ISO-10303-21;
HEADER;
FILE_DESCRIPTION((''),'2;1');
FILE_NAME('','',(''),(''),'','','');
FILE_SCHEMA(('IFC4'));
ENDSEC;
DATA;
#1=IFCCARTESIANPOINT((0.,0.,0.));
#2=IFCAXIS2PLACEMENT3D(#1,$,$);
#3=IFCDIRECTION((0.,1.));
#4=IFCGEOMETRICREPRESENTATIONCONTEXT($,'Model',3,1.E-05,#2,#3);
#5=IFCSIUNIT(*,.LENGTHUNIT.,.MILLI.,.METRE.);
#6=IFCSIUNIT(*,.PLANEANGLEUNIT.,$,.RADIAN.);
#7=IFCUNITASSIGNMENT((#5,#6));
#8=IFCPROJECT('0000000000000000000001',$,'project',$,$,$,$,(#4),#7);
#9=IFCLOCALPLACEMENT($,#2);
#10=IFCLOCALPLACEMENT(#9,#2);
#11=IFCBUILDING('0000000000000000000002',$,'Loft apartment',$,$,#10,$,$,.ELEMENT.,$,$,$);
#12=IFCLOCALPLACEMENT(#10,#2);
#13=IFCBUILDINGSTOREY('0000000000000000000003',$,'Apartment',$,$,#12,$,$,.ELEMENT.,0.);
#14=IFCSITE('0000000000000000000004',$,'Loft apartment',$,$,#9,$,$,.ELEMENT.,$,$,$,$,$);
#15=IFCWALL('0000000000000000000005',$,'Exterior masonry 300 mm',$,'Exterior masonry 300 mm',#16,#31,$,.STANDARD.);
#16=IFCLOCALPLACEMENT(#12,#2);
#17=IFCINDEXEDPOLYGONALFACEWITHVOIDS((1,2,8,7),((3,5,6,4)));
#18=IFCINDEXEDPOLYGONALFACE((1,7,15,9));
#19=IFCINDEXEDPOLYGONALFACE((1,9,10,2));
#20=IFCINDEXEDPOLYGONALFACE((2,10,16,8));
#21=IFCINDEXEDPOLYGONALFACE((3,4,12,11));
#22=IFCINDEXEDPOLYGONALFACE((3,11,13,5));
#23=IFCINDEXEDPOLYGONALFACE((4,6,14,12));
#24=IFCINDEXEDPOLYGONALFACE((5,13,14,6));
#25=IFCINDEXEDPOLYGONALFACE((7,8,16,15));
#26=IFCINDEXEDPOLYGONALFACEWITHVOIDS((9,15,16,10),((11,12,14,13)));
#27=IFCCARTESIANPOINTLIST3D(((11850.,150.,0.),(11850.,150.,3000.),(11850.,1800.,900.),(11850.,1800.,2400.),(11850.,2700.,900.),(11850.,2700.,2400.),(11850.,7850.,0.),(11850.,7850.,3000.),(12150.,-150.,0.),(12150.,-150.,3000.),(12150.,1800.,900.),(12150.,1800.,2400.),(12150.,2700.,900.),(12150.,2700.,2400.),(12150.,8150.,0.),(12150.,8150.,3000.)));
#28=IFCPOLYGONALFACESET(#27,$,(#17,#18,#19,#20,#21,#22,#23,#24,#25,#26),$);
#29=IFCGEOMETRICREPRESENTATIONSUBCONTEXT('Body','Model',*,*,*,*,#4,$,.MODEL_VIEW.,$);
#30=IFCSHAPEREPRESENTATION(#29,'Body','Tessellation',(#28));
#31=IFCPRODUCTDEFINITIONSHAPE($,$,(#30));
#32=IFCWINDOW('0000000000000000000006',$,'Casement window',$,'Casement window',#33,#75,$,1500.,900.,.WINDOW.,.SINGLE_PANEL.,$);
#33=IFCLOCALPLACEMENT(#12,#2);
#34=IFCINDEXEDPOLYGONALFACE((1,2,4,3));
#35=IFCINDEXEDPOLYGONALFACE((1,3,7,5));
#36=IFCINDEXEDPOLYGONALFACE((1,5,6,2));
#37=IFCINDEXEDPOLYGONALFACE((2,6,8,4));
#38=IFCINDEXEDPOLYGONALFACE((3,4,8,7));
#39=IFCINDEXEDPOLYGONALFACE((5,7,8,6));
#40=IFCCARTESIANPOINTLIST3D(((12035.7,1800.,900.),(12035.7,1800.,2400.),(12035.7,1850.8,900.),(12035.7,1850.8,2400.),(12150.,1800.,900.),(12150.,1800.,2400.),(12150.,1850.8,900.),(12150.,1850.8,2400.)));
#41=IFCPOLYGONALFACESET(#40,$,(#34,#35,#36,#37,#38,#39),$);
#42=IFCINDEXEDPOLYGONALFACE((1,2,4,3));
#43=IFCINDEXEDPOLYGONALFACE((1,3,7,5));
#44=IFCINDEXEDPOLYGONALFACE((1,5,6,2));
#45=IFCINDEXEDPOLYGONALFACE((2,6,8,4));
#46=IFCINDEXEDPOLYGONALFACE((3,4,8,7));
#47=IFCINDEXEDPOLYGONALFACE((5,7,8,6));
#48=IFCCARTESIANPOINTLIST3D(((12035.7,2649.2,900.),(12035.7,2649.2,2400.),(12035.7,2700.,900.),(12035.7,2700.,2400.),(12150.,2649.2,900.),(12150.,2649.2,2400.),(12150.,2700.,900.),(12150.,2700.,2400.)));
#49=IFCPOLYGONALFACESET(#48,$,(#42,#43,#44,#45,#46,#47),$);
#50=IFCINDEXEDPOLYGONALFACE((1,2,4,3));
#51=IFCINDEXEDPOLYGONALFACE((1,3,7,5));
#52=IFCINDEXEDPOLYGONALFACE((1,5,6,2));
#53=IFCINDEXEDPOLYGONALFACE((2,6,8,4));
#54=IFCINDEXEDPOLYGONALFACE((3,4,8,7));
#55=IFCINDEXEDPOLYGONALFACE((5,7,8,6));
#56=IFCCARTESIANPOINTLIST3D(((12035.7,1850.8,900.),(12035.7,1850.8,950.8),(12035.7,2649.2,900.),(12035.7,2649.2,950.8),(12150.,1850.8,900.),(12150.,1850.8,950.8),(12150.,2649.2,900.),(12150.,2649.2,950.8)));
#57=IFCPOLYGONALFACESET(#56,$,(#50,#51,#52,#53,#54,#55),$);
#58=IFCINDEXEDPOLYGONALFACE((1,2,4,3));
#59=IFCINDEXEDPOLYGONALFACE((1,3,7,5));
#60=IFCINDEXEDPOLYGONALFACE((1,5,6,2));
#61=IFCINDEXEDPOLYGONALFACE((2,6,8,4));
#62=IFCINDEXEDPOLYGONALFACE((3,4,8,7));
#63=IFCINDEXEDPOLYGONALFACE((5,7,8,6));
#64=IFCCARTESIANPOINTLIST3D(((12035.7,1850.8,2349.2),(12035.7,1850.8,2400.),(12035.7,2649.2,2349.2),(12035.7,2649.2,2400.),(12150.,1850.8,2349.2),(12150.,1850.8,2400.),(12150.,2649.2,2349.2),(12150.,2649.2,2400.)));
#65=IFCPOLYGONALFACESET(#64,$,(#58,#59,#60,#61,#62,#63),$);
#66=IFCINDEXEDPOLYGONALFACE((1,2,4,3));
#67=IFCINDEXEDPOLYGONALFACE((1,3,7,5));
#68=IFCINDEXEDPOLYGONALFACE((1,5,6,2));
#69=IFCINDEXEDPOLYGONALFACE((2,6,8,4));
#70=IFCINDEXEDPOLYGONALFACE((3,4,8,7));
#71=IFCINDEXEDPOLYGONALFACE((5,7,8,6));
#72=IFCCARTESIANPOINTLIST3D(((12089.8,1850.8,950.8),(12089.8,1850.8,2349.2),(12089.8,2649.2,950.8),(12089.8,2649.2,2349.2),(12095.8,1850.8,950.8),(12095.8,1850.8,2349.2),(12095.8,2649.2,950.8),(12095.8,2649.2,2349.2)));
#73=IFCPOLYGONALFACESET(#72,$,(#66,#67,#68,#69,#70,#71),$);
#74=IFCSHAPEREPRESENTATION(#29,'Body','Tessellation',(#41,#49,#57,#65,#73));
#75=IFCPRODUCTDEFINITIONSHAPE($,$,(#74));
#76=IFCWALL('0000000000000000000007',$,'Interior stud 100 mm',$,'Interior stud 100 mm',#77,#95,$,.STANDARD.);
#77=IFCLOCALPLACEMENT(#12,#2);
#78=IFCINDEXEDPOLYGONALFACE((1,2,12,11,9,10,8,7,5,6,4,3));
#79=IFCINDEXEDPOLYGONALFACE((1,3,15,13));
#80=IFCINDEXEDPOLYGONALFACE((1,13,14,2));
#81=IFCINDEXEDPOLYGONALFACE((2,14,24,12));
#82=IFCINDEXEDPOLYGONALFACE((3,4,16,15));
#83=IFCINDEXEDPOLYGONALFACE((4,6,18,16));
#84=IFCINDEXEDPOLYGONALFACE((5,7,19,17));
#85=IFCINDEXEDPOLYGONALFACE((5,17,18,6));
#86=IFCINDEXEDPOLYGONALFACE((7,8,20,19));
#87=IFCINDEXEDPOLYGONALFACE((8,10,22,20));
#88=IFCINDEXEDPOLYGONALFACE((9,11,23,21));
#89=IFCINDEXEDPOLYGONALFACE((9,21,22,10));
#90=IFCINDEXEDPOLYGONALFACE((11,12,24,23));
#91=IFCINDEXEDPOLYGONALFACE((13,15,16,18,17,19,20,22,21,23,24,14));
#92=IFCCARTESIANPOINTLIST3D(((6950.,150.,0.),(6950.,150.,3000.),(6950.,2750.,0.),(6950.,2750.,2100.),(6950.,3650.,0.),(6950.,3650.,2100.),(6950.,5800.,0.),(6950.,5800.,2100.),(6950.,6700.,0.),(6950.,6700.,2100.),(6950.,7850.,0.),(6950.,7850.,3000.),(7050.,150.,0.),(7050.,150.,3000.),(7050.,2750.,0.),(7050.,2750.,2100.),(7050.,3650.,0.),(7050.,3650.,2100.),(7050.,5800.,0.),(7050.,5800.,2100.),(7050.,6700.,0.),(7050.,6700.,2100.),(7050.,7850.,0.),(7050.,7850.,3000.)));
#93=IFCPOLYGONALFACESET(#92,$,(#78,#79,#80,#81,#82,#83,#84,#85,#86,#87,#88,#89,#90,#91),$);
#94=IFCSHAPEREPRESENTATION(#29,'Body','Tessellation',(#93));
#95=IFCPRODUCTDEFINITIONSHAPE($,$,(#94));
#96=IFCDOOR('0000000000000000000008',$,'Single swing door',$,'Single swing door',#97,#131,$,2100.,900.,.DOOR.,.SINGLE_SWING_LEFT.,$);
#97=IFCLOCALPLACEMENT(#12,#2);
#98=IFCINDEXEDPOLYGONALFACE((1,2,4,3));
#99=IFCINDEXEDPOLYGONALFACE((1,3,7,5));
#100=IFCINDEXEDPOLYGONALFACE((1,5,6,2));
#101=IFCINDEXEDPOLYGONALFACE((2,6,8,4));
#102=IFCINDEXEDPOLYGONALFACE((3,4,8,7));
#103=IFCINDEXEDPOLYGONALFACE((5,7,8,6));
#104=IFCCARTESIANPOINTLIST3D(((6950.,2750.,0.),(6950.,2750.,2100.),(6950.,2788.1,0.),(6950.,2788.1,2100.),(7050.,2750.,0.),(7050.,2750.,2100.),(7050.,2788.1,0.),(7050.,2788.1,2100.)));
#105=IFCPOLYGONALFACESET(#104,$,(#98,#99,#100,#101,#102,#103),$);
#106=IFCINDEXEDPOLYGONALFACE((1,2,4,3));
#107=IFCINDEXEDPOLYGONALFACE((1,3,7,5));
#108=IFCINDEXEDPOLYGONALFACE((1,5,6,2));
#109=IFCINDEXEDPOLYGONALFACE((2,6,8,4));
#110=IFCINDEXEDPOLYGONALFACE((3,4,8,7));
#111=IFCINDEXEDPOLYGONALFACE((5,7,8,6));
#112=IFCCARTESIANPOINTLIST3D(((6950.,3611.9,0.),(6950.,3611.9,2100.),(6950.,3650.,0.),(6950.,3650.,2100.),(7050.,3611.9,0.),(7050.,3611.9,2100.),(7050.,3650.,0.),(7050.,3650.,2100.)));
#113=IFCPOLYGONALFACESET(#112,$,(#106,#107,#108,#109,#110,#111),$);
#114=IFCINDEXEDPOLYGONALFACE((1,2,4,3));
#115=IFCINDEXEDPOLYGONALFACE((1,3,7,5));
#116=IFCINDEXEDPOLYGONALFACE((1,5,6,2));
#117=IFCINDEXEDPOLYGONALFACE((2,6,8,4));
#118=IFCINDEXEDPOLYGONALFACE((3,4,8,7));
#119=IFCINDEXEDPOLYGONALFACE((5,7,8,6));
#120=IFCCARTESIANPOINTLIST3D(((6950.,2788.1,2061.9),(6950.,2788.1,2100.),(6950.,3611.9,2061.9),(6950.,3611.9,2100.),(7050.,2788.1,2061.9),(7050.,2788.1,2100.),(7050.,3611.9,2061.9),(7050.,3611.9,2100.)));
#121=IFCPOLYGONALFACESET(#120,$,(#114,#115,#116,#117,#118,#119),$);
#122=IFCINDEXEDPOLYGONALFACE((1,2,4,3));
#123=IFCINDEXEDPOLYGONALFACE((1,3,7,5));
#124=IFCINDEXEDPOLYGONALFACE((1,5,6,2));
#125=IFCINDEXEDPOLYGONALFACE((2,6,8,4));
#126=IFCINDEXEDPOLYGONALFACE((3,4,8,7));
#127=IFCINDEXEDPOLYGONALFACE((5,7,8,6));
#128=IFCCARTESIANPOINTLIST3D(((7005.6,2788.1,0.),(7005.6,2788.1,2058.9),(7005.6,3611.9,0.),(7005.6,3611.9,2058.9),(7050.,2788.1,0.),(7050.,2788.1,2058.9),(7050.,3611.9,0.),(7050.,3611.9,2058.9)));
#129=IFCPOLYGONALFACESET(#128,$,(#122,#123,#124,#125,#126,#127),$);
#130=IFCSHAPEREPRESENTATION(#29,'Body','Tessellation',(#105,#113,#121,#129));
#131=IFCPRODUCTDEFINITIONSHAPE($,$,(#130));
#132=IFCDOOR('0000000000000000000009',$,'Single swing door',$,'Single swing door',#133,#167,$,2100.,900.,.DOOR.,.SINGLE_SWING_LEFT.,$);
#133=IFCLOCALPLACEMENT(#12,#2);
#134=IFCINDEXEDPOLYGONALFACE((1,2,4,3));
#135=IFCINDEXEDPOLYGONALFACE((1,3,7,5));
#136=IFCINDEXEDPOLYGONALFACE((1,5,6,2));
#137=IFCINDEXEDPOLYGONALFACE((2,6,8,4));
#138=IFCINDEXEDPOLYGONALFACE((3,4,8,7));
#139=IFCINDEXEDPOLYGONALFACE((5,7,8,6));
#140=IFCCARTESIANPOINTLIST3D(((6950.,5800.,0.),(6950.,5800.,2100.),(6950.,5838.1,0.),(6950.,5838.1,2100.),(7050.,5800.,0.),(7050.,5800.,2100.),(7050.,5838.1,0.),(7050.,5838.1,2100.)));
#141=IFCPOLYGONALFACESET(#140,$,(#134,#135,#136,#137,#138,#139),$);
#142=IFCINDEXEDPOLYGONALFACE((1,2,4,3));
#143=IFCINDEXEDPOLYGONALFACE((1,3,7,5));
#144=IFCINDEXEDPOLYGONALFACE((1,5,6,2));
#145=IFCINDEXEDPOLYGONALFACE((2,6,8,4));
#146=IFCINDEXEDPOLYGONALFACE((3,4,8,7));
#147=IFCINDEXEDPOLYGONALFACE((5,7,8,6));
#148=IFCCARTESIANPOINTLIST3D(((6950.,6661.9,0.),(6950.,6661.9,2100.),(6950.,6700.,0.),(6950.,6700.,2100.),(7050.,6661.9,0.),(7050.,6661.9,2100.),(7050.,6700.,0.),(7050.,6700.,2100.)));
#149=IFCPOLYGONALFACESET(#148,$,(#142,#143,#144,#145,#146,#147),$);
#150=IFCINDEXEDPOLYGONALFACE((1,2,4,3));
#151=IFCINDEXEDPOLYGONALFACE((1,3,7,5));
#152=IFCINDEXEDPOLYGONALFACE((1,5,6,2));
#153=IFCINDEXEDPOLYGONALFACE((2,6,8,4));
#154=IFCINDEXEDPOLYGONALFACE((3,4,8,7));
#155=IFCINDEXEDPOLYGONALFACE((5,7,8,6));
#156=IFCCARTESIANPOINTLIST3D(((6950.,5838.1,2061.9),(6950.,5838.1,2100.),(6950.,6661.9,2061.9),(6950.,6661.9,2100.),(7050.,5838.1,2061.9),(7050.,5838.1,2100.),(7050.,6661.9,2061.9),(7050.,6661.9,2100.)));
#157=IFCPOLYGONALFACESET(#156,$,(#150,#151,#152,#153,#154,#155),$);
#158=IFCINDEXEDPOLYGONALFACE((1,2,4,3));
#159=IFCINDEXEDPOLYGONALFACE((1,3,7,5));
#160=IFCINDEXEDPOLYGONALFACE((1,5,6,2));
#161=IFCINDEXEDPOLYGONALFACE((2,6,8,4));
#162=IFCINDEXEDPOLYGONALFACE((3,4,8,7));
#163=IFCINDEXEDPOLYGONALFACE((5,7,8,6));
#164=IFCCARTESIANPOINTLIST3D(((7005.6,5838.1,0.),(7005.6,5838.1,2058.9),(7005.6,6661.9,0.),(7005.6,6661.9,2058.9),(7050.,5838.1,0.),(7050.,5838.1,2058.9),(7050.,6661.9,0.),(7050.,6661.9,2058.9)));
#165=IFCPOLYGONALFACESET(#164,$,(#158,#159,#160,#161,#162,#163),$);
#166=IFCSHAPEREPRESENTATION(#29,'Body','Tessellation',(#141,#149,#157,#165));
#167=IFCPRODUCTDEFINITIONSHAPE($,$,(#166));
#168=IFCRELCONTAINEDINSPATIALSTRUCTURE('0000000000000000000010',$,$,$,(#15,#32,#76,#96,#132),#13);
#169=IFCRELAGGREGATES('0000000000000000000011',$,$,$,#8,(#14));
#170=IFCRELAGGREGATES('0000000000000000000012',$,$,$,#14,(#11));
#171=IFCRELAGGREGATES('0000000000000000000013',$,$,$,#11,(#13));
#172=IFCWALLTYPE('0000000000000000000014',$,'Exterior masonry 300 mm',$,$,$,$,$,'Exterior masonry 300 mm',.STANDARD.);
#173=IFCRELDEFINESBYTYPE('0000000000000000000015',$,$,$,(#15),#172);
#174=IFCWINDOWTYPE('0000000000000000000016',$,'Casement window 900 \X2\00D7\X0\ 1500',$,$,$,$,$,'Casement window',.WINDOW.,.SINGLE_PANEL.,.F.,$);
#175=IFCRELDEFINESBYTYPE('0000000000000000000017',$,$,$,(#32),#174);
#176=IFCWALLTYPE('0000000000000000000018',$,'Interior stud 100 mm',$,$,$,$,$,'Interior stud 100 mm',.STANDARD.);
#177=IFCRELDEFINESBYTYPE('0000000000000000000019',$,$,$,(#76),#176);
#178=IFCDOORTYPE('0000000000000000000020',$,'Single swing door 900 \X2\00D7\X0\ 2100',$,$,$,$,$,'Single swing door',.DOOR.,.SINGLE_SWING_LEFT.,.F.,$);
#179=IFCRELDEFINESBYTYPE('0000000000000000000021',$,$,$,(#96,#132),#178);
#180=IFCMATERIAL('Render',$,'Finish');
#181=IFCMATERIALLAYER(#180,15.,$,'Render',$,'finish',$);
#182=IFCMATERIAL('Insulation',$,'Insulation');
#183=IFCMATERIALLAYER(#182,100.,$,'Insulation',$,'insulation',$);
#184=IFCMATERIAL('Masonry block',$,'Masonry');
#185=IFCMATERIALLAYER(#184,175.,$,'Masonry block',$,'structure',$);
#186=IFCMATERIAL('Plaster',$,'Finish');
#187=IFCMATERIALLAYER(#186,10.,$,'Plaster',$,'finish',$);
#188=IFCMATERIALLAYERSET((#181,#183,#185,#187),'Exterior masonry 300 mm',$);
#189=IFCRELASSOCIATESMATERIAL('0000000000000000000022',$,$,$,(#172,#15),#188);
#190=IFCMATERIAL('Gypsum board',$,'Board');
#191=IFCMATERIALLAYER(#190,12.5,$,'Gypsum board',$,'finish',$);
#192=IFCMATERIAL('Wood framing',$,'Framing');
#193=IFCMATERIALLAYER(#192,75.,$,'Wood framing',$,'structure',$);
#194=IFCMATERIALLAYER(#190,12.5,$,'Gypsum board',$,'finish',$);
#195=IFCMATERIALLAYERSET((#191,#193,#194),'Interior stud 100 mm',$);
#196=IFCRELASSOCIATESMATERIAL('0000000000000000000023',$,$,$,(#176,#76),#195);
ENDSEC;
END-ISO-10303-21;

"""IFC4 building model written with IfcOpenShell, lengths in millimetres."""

from ifc_helpers import new_model, si_unit, direction, frame, origin, origin_with_axes, place, context, subcontext, project, spatial, polyline, outline, extrude, material, layer, layer_set, layer_usage, type_object, element, fill, save


model = new_model("IFC4")

# Units and contexts
model_context = context("Model", 3, precision=1e-05, world=origin(), true_north=direction((0.0, 1.0)))
body_context = subcontext(model_context, "Body", "Model", "MODEL_VIEW")
ifc_project = project(units=[si_unit("LENGTHUNIT", "METRE", prefix="MILLI"), si_unit("PLANEANGLEUNIT", "RADIAN")], contexts=[model_context])

# Site, building, storey
site_placement = place(None, origin())
site = spatial("IfcSite", under=ifc_project, at=site_placement, Name="Loft apartment", CompositionType="ELEMENT")
building_placement = place(site_placement, origin())
building = spatial("IfcBuilding", under=site, at=building_placement, Name="Loft apartment", CompositionType="ELEMENT")
storey_placement = place(building_placement, origin())
storey = spatial("IfcBuildingStorey", under=building, at=storey_placement, Name="Apartment", CompositionType="ELEMENT", Elevation=0.0)

# Wall, opening, window
ifc_material_1 = material(Name="Render", Category="Finish")
ifc_layer_1 = layer(ifc_material_1, 15.0, Name="Render", Category="finish")
ifc_material_2 = material(Name="Insulation", Category="Insulation")
ifc_layer_2 = layer(ifc_material_2, 100.0, Name="Insulation", Category="insulation")
ifc_material_3 = material(Name="Masonry block", Category="Masonry")
ifc_layer_3 = layer(ifc_material_3, 175.0, Name="Masonry block", Category="structure")
ifc_material_4 = material(Name="Plaster", Category="Finish")
ifc_layer_4 = layer(ifc_material_4, 10.0, Name="Plaster", Category="finish")
ifc_layer_set_1 = layer_set([ifc_layer_1, ifc_layer_2, ifc_layer_3, ifc_layer_4], Name="Exterior masonry 300 mm")
ifc_layer_usage_1 = layer_usage(ifc_layer_set_1, "AXIS2", "POSITIVE", -150.0)
wall_type_1 = type_object("IfcWallType", Name="Exterior masonry 300 mm", ElementType="Exterior masonry 300 mm", PredefinedType="STANDARD", material=ifc_layer_set_1)
wall_1_placement = place(storey_placement, frame((12000.0, 0.0, 0.0), z_axis=(0.0, 0.0, 1.0), x_axis=(0.0, 1.0, 0.0)))
wall_1 = element("IfcWall", 1, at=wall_1_placement, inside=storey, type_object=wall_type_1, material=ifc_layer_usage_1, Name="Exterior masonry 300 mm", ObjectType="Exterior masonry 300 mm", PredefinedType="STANDARD", context=body_context, shape_type="SweptSolid", body=[
    extrude(outline(polyline([(-150.0, -150.0), (8150.0, -150.0), (7850.0, 150.0), (150.0, 150.0), (-150.0, -150.0)])), origin(), (0.0, 0.0, 1.0), 3000.0),
])
opening_1_placement = place(wall_1_placement, frame((1800.0, 0.0, 900.0), z_axis=(0.0, 0.0, 1.0), x_axis=(1.0, 0.0, 0.0)))
opening_1 = element("IfcOpeningElement", 2, at=opening_1_placement, cuts=wall_1, PredefinedType="OPENING", context=body_context, shape_type="SweptSolid", body=[
    extrude(outline(polyline([(0.0, -160.0), (900.0, -160.0), (900.0, 160.0), (0.0, 160.0), (0.0, -160.0)])), origin(), (0.0, 0.0, 1.0), 1500.0),
])
window_type_1 = type_object("IfcWindowType", Name="Casement window 900 × 1500", ElementType="Casement window", ParameterTakesPrecedence=False, PartitioningType="SINGLE_PANEL", PredefinedType="WINDOW")
window_1_placement = place(opening_1_placement, origin_with_axes())
window_1 = element("IfcWindow", 3, at=window_1_placement, inside=storey, type_object=window_type_1, Name="Casement window", ObjectType="Casement window", OverallHeight=1500.0, OverallWidth=900.0, PartitioningType="SINGLE_PANEL", PredefinedType="WINDOW", context=body_context, shape_type="SweptSolid", body=[
    extrude(outline(polyline([(0.0, -150.0), (50.8, -150.0), (50.8, -35.7), (0.0, -35.7), (0.0, -150.0)])), origin(), (0.0, 0.0, 1.0), 1500.0),
    extrude(outline(polyline([(849.2, -150.0), (900.0, -150.0), (900.0, -35.7), (849.2, -35.7), (849.2, -150.0)])), origin(), (0.0, 0.0, 1.0), 1500.0),
    extrude(outline(polyline([(50.8, -150.0), (849.2, -150.0), (849.2, -35.7), (50.8, -35.7), (50.8, -150.0)])), origin(), (0.0, 0.0, 1.0), 50.8),
    extrude(outline(polyline([(50.8, -150.0), (849.2, -150.0), (849.2, -35.7), (50.8, -35.7), (50.8, -150.0)])), frame((0.0, 0.0, 1449.2)), (0.0, 0.0, 1.0), 50.8),
    extrude(outline(polyline([(50.8, -95.8), (849.2, -95.8), (849.2, -89.8), (50.8, -89.8), (50.8, -95.8)])), frame((0.0, 0.0, 50.8)), (0.0, 0.0, 1.0), 1398.4),
])
fill(opening_1, window_1)

# Wall, openings, doors
ifc_material_5 = material(Name="Gypsum board", Category="Board")
ifc_layer_5 = layer(ifc_material_5, 12.5, Name="Gypsum board", Category="finish")
ifc_material_6 = material(Name="Wood framing", Category="Framing")
ifc_layer_6 = layer(ifc_material_6, 75.0, Name="Wood framing", Category="structure")
ifc_layer_7 = layer(ifc_material_5, 12.5, Name="Gypsum board", Category="finish")
ifc_layer_set_2 = layer_set([ifc_layer_5, ifc_layer_6, ifc_layer_7], Name="Interior stud 100 mm")
ifc_layer_usage_2 = layer_usage(ifc_layer_set_2, "AXIS2", "NEGATIVE", 50.0)
wall_type_2 = type_object("IfcWallType", Name="Interior stud 100 mm", ElementType="Interior stud 100 mm", PredefinedType="STANDARD", material=ifc_layer_set_2)
wall_2_placement = place(storey_placement, frame((7000.0, 0.0, 0.0), z_axis=(0.0, 0.0, 1.0), x_axis=(0.0, 1.0, 0.0)))
wall_2 = element("IfcWall", 4, at=wall_2_placement, inside=storey, type_object=wall_type_2, material=ifc_layer_usage_2, Name="Interior stud 100 mm", ObjectType="Interior stud 100 mm", PredefinedType="STANDARD", context=body_context, shape_type="SweptSolid", body=[
    extrude(outline(polyline([(150.0, -50.0), (7850.0, -50.0), (7850.0, 50.0), (150.0, 50.0), (150.0, -50.0)])), origin(), (0.0, 0.0, 1.0), 3000.0),
])
opening_2_placement = place(wall_2_placement, frame((2750.0, 0.0, 0.0), z_axis=(0.0, 0.0, 1.0), x_axis=(1.0, 0.0, 0.0)))
opening_2 = element("IfcOpeningElement", 5, at=opening_2_placement, cuts=wall_2, PredefinedType="OPENING", context=body_context, shape_type="SweptSolid", body=[
    extrude(outline(polyline([(0.0, -60.0), (900.0, -60.0), (900.0, 60.0), (0.0, 60.0), (0.0, -60.0)])), origin(), (0.0, 0.0, 1.0), 2100.0),
])
opening_3_placement = place(wall_2_placement, frame((5800.0, 0.0, 0.0), z_axis=(0.0, 0.0, 1.0), x_axis=(1.0, 0.0, 0.0)))
opening_3 = element("IfcOpeningElement", 6, at=opening_3_placement, cuts=wall_2, PredefinedType="OPENING", context=body_context, shape_type="SweptSolid", body=[
    extrude(outline(polyline([(0.0, -60.0), (900.0, -60.0), (900.0, 60.0), (0.0, 60.0), (0.0, -60.0)])), origin(), (0.0, 0.0, 1.0), 2100.0),
])
door_type_1 = type_object("IfcDoorType", Name="Single swing door 900 × 2100", ElementType="Single swing door", OperationType="SINGLE_SWING_LEFT", ParameterTakesPrecedence=False, PredefinedType="DOOR")
door_1_placement = place(opening_2_placement, origin_with_axes())
door_1 = element("IfcDoor", 7, at=door_1_placement, inside=storey, type_object=door_type_1, Name="Single swing door", ObjectType="Single swing door", OperationType="SINGLE_SWING_LEFT", OverallHeight=2100.0, OverallWidth=900.0, PredefinedType="DOOR", context=body_context, shape_type="SweptSolid", body=[
    extrude(outline(polyline([(0.0, -50.0), (38.1, -50.0), (38.1, 50.0), (0.0, 50.0), (0.0, -50.0)])), origin(), (0.0, 0.0, 1.0), 2100.0),
    extrude(outline(polyline([(861.9, -50.0), (900.0, -50.0), (900.0, 50.0), (861.9, 50.0), (861.9, -50.0)])), origin(), (0.0, 0.0, 1.0), 2100.0),
    extrude(outline(polyline([(38.1, -50.0), (861.9, -50.0), (861.9, 50.0), (38.1, 50.0), (38.1, -50.0)])), frame((0.0, 0.0, 2061.9)), (0.0, 0.0, 1.0), 38.1),
    extrude(outline(polyline([(38.1, -50.0), (861.9, -50.0), (861.9, -5.5), (38.1, -5.5), (38.1, -50.0)])), origin(), (0.0, 0.0, 1.0), 2058.9),
])
fill(opening_2, door_1)
door_2_placement = place(opening_3_placement, origin_with_axes())
door_2 = element("IfcDoor", 8, at=door_2_placement, inside=storey, type_object=door_type_1, Name="Single swing door", ObjectType="Single swing door", OperationType="SINGLE_SWING_LEFT", OverallHeight=2100.0, OverallWidth=900.0, PredefinedType="DOOR", context=body_context, shape_type="SweptSolid", body=[
    extrude(outline(polyline([(0.0, -50.0), (38.1, -50.0), (38.1, 50.0), (0.0, 50.0), (0.0, -50.0)])), origin(), (0.0, 0.0, 1.0), 2100.0),
    extrude(outline(polyline([(861.9, -50.0), (900.0, -50.0), (900.0, 50.0), (861.9, 50.0), (861.9, -50.0)])), origin(), (0.0, 0.0, 1.0), 2100.0),
    extrude(outline(polyline([(38.1, -50.0), (861.9, -50.0), (861.9, 50.0), (38.1, 50.0), (38.1, -50.0)])), frame((0.0, 0.0, 2061.9)), (0.0, 0.0, 1.0), 38.1),
    extrude(outline(polyline([(38.1, -50.0), (861.9, -50.0), (861.9, -5.5), (38.1, -5.5), (38.1, -50.0)])), origin(), (0.0, 0.0, 1.0), 2058.9),
])
fill(opening_3, door_2)

save(model, "model.ifc")
